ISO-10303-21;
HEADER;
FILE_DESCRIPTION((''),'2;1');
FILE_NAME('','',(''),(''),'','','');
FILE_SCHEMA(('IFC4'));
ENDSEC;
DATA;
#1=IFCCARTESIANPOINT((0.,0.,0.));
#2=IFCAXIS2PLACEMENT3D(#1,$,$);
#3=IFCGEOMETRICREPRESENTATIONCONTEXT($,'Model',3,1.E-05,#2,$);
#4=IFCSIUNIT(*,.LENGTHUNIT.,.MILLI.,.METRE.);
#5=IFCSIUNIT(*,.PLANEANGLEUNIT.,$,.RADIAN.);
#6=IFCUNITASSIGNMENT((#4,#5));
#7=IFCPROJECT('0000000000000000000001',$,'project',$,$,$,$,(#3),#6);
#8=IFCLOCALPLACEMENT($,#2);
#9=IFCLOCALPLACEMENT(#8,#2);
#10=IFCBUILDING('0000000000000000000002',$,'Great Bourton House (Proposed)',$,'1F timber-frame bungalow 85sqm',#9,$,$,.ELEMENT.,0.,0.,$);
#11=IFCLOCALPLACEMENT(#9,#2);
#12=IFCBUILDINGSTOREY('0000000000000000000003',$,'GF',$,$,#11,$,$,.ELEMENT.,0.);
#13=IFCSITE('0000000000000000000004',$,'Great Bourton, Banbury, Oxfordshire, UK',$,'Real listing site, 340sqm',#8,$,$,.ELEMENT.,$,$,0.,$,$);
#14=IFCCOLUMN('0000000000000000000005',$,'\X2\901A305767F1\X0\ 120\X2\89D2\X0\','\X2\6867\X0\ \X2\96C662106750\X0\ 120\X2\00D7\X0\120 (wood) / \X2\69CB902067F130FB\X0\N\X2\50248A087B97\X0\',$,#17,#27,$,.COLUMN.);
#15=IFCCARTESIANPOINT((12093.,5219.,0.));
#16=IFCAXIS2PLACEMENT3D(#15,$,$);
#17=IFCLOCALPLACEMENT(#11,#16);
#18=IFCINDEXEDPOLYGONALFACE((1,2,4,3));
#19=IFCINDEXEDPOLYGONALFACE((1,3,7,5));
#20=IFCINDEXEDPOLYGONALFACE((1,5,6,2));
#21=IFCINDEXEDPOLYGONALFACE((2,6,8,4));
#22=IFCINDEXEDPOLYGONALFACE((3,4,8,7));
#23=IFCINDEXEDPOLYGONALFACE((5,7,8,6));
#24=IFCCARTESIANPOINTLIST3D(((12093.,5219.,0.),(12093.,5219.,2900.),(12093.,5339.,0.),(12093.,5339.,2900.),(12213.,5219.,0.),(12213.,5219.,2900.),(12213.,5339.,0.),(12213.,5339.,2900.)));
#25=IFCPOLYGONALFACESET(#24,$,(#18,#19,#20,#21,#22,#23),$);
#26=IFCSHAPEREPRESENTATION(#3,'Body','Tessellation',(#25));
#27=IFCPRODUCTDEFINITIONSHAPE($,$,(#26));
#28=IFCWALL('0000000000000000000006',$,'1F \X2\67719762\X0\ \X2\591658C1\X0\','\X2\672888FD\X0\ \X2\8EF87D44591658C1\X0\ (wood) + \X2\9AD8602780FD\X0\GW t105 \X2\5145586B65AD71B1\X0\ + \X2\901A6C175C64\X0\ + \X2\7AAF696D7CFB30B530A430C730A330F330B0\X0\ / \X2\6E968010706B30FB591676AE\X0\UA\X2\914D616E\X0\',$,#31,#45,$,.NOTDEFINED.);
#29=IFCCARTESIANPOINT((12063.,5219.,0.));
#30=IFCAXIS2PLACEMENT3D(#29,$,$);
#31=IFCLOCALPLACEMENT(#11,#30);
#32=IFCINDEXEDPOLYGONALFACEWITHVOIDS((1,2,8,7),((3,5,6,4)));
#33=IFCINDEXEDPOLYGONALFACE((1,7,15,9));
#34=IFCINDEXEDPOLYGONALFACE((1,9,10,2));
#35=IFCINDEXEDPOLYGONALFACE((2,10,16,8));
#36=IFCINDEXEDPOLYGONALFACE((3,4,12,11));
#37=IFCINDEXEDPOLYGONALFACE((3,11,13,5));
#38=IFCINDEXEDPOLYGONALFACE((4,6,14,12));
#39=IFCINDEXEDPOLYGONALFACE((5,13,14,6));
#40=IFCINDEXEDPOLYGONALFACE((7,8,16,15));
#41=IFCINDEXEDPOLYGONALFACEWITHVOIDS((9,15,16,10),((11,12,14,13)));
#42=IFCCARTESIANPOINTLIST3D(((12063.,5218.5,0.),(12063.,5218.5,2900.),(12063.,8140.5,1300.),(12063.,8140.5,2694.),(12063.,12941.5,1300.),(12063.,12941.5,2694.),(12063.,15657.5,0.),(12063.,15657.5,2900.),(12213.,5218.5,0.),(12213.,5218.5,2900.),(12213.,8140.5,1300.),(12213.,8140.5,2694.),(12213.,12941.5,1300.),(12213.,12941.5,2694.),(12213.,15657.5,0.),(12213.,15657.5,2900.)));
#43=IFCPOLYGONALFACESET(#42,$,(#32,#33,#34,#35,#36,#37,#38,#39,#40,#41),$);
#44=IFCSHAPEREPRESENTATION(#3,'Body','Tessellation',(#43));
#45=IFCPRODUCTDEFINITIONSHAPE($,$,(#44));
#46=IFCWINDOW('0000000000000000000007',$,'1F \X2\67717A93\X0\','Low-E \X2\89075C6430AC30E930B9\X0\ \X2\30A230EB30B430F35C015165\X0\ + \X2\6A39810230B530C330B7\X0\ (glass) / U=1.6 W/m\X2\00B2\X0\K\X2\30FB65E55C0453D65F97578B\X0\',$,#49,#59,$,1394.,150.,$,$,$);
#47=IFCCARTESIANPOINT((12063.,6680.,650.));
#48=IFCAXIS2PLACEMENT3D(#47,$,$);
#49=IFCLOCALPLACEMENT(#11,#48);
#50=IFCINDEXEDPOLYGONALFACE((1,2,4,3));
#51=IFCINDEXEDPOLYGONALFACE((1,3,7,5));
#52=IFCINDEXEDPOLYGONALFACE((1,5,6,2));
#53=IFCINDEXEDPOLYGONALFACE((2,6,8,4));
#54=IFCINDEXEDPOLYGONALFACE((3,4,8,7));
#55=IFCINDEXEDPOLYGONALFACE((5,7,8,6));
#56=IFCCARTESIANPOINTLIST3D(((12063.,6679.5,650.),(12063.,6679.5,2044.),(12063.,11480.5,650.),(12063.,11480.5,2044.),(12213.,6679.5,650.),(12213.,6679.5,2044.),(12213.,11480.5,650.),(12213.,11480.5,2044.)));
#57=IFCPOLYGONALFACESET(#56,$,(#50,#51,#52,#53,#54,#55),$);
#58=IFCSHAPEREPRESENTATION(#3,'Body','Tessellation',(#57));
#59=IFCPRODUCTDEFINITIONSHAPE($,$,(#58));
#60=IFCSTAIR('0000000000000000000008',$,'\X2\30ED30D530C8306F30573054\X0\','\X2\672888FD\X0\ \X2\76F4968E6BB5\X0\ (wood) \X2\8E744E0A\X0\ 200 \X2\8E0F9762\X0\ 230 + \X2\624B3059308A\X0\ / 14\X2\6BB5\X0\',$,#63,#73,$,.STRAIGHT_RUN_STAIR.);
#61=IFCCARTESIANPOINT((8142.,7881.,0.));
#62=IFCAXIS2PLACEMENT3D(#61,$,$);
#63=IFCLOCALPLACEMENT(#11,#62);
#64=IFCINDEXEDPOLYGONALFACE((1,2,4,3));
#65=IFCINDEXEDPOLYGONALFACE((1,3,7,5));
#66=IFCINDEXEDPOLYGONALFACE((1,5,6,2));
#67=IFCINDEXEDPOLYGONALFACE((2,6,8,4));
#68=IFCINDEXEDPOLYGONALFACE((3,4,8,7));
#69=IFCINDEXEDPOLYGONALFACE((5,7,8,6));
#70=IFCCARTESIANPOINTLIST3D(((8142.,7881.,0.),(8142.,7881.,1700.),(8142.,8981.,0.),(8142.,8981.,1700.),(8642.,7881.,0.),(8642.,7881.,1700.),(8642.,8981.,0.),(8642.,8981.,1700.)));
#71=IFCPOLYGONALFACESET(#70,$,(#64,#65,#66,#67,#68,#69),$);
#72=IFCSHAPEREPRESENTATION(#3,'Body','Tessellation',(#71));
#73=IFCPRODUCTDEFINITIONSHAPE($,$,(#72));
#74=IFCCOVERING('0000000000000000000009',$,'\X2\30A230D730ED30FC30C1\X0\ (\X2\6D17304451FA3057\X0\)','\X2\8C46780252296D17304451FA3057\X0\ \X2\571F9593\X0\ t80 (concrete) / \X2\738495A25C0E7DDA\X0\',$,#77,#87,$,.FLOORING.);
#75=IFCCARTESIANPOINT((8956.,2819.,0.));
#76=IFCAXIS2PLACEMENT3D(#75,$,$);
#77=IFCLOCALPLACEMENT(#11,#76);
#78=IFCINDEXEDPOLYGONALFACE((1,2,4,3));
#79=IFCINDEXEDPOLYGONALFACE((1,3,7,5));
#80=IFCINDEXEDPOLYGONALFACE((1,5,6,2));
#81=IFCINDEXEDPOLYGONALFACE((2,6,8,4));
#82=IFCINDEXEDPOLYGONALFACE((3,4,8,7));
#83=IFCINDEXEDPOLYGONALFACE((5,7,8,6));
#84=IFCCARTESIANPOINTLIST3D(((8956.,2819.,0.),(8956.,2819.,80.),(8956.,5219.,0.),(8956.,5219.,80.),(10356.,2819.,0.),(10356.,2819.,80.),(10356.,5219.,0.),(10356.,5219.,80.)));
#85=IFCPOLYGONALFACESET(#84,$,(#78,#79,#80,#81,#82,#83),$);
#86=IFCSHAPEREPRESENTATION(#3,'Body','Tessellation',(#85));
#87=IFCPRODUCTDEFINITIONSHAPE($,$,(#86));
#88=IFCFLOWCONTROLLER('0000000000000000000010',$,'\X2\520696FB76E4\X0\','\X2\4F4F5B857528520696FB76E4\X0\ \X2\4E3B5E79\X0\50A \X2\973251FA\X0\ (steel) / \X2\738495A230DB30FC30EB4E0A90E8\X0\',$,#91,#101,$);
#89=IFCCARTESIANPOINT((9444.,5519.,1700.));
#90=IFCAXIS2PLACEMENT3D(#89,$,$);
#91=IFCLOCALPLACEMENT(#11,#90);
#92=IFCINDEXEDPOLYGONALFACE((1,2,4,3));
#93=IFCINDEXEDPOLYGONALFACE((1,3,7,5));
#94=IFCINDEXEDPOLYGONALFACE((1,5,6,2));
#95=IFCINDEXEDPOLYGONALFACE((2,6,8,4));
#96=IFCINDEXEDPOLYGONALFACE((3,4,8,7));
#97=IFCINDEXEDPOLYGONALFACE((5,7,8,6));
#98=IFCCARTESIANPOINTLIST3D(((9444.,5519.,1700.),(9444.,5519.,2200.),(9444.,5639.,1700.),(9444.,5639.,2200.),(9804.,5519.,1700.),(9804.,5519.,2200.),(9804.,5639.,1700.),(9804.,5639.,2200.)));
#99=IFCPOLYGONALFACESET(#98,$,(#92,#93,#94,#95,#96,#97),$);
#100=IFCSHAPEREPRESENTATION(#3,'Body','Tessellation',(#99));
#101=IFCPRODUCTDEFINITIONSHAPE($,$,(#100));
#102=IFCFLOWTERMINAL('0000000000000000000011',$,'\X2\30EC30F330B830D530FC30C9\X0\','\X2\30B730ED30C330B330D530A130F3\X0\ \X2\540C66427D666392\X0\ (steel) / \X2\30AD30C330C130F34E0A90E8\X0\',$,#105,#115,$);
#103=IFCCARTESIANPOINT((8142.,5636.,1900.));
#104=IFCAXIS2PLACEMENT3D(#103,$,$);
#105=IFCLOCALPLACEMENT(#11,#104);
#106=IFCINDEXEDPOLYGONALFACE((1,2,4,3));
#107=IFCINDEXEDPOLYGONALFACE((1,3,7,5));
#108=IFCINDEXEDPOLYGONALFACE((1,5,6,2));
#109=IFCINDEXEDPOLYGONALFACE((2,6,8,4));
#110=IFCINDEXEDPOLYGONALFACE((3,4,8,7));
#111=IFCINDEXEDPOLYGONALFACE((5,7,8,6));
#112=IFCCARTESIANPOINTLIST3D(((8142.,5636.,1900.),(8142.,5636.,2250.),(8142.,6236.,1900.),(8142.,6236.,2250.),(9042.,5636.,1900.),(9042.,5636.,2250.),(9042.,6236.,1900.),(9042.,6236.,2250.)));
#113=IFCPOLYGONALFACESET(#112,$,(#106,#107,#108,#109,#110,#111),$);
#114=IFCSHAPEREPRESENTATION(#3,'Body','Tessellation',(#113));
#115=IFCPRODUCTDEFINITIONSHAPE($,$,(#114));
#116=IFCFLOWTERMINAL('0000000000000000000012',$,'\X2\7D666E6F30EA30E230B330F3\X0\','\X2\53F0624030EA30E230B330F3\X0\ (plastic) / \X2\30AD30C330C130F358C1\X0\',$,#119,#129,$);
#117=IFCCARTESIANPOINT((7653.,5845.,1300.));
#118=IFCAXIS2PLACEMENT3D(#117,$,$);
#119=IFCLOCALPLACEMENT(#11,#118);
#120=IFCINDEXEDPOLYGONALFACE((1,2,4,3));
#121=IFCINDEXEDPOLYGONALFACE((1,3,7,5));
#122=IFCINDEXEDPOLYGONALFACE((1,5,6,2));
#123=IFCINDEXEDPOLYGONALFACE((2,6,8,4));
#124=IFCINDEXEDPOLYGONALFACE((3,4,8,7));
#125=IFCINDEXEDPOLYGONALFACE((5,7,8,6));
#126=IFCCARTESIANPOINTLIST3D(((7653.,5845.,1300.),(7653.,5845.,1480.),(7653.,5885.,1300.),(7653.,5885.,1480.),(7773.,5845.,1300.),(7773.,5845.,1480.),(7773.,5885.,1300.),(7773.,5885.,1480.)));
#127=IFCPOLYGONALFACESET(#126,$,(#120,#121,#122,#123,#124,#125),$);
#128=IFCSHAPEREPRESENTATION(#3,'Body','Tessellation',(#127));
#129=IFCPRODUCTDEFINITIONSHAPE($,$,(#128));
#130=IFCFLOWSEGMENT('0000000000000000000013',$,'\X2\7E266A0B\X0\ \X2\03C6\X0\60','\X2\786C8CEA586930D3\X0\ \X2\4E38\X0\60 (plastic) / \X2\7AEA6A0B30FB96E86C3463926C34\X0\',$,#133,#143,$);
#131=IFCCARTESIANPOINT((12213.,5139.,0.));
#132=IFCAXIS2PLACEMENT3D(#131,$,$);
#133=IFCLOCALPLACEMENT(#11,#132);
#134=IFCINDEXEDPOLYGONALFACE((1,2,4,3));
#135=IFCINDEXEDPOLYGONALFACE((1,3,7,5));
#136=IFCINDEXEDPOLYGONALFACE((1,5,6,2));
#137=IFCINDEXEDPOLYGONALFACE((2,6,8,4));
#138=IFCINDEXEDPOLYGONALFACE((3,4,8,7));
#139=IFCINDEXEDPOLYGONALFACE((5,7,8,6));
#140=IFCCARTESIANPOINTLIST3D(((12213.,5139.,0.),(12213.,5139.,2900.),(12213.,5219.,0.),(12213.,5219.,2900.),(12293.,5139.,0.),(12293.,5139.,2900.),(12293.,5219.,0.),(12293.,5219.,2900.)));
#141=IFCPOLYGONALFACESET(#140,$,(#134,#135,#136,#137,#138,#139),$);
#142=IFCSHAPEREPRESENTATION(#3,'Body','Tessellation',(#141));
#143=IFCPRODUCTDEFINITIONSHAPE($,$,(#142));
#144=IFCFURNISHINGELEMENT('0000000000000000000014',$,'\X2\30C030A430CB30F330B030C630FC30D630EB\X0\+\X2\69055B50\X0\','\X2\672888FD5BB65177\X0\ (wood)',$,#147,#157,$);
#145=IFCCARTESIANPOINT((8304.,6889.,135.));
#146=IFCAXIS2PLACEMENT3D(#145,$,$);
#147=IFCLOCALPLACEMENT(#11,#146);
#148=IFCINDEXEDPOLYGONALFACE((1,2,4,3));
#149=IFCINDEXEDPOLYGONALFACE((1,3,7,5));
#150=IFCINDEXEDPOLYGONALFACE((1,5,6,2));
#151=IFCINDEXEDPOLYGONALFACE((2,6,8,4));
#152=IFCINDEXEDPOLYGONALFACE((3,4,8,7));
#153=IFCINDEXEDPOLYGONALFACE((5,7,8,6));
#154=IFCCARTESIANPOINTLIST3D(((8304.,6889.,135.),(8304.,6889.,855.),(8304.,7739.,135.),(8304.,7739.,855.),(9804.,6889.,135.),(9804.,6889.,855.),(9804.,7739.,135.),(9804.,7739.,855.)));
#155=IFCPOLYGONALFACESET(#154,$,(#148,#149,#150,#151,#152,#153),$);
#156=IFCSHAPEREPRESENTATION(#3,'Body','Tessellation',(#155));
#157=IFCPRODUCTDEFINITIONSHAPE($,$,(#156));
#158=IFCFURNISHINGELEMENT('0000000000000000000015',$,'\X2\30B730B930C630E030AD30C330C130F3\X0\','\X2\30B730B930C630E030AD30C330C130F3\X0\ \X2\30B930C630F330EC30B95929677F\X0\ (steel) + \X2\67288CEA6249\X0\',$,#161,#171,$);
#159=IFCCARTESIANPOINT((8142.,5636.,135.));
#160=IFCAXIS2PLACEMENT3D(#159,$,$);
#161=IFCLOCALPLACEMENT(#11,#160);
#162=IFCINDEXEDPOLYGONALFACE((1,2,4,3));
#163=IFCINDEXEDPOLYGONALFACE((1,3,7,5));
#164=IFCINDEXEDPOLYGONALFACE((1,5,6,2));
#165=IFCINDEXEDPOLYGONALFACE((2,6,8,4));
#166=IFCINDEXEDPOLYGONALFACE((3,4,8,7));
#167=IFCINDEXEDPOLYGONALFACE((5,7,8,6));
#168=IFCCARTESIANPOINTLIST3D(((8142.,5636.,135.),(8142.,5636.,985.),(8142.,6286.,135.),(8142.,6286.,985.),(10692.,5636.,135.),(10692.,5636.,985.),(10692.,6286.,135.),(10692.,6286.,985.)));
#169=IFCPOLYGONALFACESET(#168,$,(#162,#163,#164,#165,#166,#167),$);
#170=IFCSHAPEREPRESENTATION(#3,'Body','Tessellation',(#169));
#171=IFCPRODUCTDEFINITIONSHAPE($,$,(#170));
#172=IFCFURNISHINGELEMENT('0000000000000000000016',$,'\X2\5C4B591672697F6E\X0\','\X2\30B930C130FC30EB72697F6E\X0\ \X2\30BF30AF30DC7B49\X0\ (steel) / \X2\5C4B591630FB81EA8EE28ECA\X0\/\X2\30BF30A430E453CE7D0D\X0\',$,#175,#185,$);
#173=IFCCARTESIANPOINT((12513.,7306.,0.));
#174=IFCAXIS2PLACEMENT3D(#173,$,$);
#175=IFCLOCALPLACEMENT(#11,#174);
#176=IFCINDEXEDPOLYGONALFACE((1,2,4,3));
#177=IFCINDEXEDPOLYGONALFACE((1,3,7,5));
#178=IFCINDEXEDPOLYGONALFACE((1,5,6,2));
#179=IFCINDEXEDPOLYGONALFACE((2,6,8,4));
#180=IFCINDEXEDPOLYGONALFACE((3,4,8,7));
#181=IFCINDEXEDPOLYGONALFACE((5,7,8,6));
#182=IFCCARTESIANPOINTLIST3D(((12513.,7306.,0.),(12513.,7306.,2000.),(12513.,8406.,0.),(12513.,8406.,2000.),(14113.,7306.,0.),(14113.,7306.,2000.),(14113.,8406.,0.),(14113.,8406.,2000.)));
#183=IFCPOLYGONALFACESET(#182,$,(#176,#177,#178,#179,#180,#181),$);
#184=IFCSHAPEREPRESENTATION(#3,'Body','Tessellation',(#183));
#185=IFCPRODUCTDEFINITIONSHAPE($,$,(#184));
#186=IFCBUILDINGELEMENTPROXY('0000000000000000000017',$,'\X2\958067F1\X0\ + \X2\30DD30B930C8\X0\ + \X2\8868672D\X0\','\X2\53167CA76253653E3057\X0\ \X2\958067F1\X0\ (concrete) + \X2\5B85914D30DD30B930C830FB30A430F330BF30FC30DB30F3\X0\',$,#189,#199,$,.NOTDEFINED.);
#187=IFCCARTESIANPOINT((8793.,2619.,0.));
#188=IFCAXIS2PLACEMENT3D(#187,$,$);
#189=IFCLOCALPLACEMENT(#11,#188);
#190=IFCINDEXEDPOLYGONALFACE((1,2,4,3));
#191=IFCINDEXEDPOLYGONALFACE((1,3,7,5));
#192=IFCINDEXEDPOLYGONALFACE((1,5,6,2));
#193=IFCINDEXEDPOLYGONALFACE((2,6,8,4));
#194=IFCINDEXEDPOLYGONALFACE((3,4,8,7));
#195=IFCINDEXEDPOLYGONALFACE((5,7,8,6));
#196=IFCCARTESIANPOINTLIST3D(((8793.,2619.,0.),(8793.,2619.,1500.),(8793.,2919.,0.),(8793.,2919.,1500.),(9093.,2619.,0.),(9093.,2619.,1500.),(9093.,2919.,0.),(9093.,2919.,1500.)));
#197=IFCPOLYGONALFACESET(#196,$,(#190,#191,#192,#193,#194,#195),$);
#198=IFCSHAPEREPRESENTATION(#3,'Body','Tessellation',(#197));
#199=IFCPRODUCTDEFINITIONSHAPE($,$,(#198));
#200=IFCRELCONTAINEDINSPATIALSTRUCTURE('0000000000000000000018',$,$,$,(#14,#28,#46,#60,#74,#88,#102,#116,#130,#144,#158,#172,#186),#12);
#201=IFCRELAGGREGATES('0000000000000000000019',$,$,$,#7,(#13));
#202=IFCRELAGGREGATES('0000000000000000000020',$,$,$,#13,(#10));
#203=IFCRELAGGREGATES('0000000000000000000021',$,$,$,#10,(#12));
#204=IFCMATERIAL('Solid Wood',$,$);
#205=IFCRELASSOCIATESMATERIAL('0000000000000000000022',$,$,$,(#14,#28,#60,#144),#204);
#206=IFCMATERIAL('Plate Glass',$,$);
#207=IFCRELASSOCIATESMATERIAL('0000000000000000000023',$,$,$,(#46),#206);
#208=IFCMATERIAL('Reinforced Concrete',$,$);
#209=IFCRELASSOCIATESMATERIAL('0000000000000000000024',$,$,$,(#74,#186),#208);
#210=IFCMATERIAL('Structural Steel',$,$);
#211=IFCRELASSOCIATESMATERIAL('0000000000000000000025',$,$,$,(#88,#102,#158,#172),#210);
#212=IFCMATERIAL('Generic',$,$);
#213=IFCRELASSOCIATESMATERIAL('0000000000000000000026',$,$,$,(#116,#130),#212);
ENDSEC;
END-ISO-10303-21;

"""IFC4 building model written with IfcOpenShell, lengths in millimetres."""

from ifc_helpers import new_model, si_unit, frame, frame_2d, origin, place, context, project, spatial, rectangle, extrude, material, element, fill, save


model = new_model("IFC4")

# Units and contexts
model_context = context("Model", 3, precision=1e-05, world=origin())
ifc_project = project(units=[si_unit("LENGTHUNIT", "METRE", prefix="MILLI"), si_unit("PLANEANGLEUNIT", "RADIAN")], contexts=[model_context])

# Site, building, storey
site_placement = place(None, origin())
site = spatial("IfcSite", under=ifc_project, at=site_placement, Name="Great Bourton, Banbury, Oxfordshire, UK", ObjectType="Real listing site, 340sqm", CompositionType="ELEMENT", RefElevation=0.0)
building_placement = place(site_placement, origin())
building = spatial("IfcBuilding", under=site, at=building_placement, Name="Great Bourton House (Proposed)", ObjectType="1F timber-frame bungalow 85sqm", CompositionType="ELEMENT", ElevationOfRefHeight=0.0, ElevationOfTerrain=0.0)
storey_placement = place(building_placement, origin())
storey = spatial("IfcBuildingStorey", under=building, at=storey_placement, Name="GF", CompositionType="ELEMENT", Elevation=0.0)

# Column
ifc_material_1 = material(Name="Solid Wood")
column_1_placement = place(storey_placement, frame((12093.0, 5219.0, 0.0)))
element("IfcColumn", 1, at=column_1_placement, inside=storey, material=ifc_material_1, Name="通し柱 120角", Description="桧 集成材 120×120 (wood) / 構造柱・N値計算", PredefinedType="COLUMN", context=model_context, shape_type="SweptSolid", body=[
    extrude(rectangle(XDim=120.0, YDim=120.0, at=frame_2d((60.0, 60.0))), frame((12093.0, 5219.0, 0.0)), (0.0, 0.0, 1.0), 2900.0),
])

# Wall, opening, window
wall_1_placement = place(storey_placement, frame((12063.0, 5219.0, 0.0)))
wall_1 = element("IfcWall", 2, at=wall_1_placement, inside=storey, material=ifc_material_1, Name="1F 東面 外壁", Description="木製 軸組外壁 (wood) + 高性能GW t105 充填断熱 + 通気層 + 窯業系サイディング / 準耐火・外皮UA配慮", PredefinedType="NOTDEFINED", context=model_context, shape_type="SweptSolid", body=[
    extrude(rectangle(XDim=150.0, YDim=10439.0, at=frame_2d((75.0, 5219.0))), frame((12063.0, 5219.0, 0.0)), (0.0, 0.0, 1.0), 2900.0),
])
opening_placement = place(storey_placement, frame((12063.0, 6680.0, 650.0)))
opening = element("IfcOpeningElement", 3, at=opening_placement, cuts=wall_1, PredefinedType="NOTDEFINED", context=model_context, shape_type="SweptSolid", body=[
    extrude(rectangle(XDim=150.0, YDim=4801.0, at=frame_2d((75.0, 2400.0))), frame((12063.0, 6680.0, 650.0)), (0.0, 0.0, 1.0), 1394.0),
])
ifc_material_2 = material(Name="Plate Glass")
window_placement = place(storey_placement, frame((12063.0, 6680.0, 650.0)))
window = element("IfcWindow", 4, at=window_placement, inside=storey, material=ifc_material_2, Name="1F 東窓", Description="Low-E 複層ガラス アルゴン封入 + 樹脂サッシ (glass) / U=1.6 W/m²K・日射取得型", OverallHeight=1394.0, OverallWidth=150.0, context=model_context, shape_type="SweptSolid", body=[
    extrude(rectangle(XDim=150.0, YDim=4801.0, at=frame_2d((75.0, 2400.0))), frame((12063.0, 6680.0, 650.0)), (0.0, 0.0, 1.0), 1394.0),
])
fill(opening, window)

# Stair
stair_placement = place(storey_placement, frame((8142.0, 7881.0, 0.0)))
element("IfcStair", 5, at=stair_placement, inside=storey, material=ifc_material_1, Name="ロフトはしご", Description="木製 直階段 (wood) 蹴上 200 踏面 230 + 手すり / 14段", PredefinedType="STRAIGHT_RUN_STAIR", context=model_context, shape_type="SweptSolid", body=[
    extrude(rectangle(XDim=500.0, YDim=1100.0, at=frame_2d((250.0, 550.0))), frame((8142.0, 7881.0, 0.0)), (0.0, 0.0, 1.0), 1700.0),
])

# Covering
ifc_material_3 = material(Name="Reinforced Concrete")
covering_placement = place(storey_placement, frame((8956.0, 2819.0, 0.0)))
element("IfcCovering", 6, at=covering_placement, inside=storey, material=ifc_material_3, Name="アプローチ (洗い出し)", Description="豆砂利洗い出し 土間 t80 (concrete) / 玄関導線", PredefinedType="FLOORING", context=model_context, shape_type="SweptSolid", body=[
    extrude(rectangle(XDim=1400.0, YDim=2400.0, at=frame_2d((700.0, 1200.0))), frame((8956.0, 2819.0, 0.0)), (0.0, 0.0, 1.0), 80.0),
])

# Flow controller
ifc_material_4 = material(Name="Structural Steel")
flow_controller_placement = place(storey_placement, frame((9444.0, 5519.0, 1700.0)))
element("IfcFlowController", 7, at=flow_controller_placement, inside=storey, material=ifc_material_4, Name="分電盤", Description="住宅用分電盤 主幹50A 露出 (steel) / 玄関ホール上部", context=model_context, shape_type="SweptSolid", body=[
    extrude(rectangle(XDim=360.0, YDim=120.0, at=frame_2d((180.0, 60.0))), frame((9444.0, 5519.0, 1700.0)), (0.0, 0.0, 1.0), 500.0),
])

# Flow terminals
flow_terminal_1_placement = place(storey_placement, frame((8142.0, 5636.0, 1900.0)))
element("IfcFlowTerminal", 8, at=flow_terminal_1_placement, inside=storey, material=ifc_material_4, Name="レンジフード", Description="シロッコファン 同時給排 (steel) / キッチン上部", context=model_context, shape_type="SweptSolid", body=[
    extrude(rectangle(XDim=900.0, YDim=600.0, at=frame_2d((450.0, 300.0))), frame((8142.0, 5636.0, 1900.0)), (0.0, 0.0, 1.0), 350.0),
])
ifc_material_5 = material(Name="Generic")
flow_terminal_2_placement = place(storey_placement, frame((7653.0, 5845.0, 1300.0)))
element("IfcFlowTerminal", 9, at=flow_terminal_2_placement, inside=storey, material=ifc_material_5, Name="給湯リモコン", Description="台所リモコン (plastic) / キッチン壁", context=model_context, shape_type="SweptSolid", body=[
    extrude(rectangle(XDim=120.0, YDim=40.0, at=frame_2d((60.0, 20.0))), frame((7653.0, 5845.0, 1300.0)), (0.0, 0.0, 1.0), 180.0),
])

# Flow segment
flow_segment_placement = place(storey_placement, frame((12213.0, 5139.0, 0.0)))
element("IfcFlowSegment", 10, at=flow_segment_placement, inside=storey, material=ifc_material_5, Name="縦樋 φ60", Description="硬質塩ビ 丸60 (plastic) / 竪樋・雨水排水", context=model_context, shape_type="SweptSolid", body=[
    extrude(rectangle(XDim=80.0, YDim=80.0, at=frame_2d((40.0, 40.0))), frame((12213.0, 5139.0, 0.0)), (0.0, 0.0, 1.0), 2900.0),
])

# Furnishing elements
furnishing_1_placement = place(storey_placement, frame((8304.0, 6889.0, 135.0)))
element("IfcFurnishingElement", 11, at=furnishing_1_placement, inside=storey, material=ifc_material_1, Name="ダイニングテーブル+椅子", Description="木製家具 (wood)", context=model_context, shape_type="SweptSolid", body=[
    extrude(rectangle(XDim=1500.0, YDim=850.0, at=frame_2d((750.0, 425.0))), frame((8304.0, 6889.0, 135.0)), (0.0, 0.0, 1.0), 720.0),
])
furnishing_2_placement = place(storey_placement, frame((8142.0, 5636.0, 135.0)))
element("IfcFurnishingElement", 12, at=furnishing_2_placement, inside=storey, material=ifc_material_4, Name="システムキッチン", Description="システムキッチン ステンレス天板 (steel) + 木質扉", context=model_context, shape_type="SweptSolid", body=[
    extrude(rectangle(XDim=2550.0, YDim=650.0, at=frame_2d((1275.0, 325.0))), frame((8142.0, 5636.0, 135.0)), (0.0, 0.0, 1.0), 850.0),
])
furnishing_3_placement = place(storey_placement, frame((12513.0, 7306.0, 0.0)))
element("IfcFurnishingElement", 13, at=furnishing_3_placement, inside=storey, material=ifc_material_4, Name="屋外物置", Description="スチール物置 タクボ等 (steel) / 屋外・自転車/タイヤ収納", context=model_context, shape_type="SweptSolid", body=[
    extrude(rectangle(XDim=1600.0, YDim=1100.0, at=frame_2d((800.0, 550.0))), frame((12513.0, 7306.0, 0.0)), (0.0, 0.0, 1.0), 2000.0),
])

# Building element proxy
proxy_placement = place(storey_placement, frame((8793.0, 2619.0, 0.0)))
element("IfcBuildingElementProxy", 14, at=proxy_placement, inside=storey, material=ifc_material_3, Name="門柱 + ポスト + 表札", Description="化粧打放し 門柱 (concrete) + 宅配ポスト・インターホン", PredefinedType="NOTDEFINED", context=model_context, shape_type="SweptSolid", body=[
    extrude(rectangle(XDim=300.0, YDim=300.0, at=frame_2d((150.0, 150.0))), frame((8793.0, 2619.0, 0.0)), (0.0, 0.0, 1.0), 1500.0),
])

save(model, "model.ifc")
